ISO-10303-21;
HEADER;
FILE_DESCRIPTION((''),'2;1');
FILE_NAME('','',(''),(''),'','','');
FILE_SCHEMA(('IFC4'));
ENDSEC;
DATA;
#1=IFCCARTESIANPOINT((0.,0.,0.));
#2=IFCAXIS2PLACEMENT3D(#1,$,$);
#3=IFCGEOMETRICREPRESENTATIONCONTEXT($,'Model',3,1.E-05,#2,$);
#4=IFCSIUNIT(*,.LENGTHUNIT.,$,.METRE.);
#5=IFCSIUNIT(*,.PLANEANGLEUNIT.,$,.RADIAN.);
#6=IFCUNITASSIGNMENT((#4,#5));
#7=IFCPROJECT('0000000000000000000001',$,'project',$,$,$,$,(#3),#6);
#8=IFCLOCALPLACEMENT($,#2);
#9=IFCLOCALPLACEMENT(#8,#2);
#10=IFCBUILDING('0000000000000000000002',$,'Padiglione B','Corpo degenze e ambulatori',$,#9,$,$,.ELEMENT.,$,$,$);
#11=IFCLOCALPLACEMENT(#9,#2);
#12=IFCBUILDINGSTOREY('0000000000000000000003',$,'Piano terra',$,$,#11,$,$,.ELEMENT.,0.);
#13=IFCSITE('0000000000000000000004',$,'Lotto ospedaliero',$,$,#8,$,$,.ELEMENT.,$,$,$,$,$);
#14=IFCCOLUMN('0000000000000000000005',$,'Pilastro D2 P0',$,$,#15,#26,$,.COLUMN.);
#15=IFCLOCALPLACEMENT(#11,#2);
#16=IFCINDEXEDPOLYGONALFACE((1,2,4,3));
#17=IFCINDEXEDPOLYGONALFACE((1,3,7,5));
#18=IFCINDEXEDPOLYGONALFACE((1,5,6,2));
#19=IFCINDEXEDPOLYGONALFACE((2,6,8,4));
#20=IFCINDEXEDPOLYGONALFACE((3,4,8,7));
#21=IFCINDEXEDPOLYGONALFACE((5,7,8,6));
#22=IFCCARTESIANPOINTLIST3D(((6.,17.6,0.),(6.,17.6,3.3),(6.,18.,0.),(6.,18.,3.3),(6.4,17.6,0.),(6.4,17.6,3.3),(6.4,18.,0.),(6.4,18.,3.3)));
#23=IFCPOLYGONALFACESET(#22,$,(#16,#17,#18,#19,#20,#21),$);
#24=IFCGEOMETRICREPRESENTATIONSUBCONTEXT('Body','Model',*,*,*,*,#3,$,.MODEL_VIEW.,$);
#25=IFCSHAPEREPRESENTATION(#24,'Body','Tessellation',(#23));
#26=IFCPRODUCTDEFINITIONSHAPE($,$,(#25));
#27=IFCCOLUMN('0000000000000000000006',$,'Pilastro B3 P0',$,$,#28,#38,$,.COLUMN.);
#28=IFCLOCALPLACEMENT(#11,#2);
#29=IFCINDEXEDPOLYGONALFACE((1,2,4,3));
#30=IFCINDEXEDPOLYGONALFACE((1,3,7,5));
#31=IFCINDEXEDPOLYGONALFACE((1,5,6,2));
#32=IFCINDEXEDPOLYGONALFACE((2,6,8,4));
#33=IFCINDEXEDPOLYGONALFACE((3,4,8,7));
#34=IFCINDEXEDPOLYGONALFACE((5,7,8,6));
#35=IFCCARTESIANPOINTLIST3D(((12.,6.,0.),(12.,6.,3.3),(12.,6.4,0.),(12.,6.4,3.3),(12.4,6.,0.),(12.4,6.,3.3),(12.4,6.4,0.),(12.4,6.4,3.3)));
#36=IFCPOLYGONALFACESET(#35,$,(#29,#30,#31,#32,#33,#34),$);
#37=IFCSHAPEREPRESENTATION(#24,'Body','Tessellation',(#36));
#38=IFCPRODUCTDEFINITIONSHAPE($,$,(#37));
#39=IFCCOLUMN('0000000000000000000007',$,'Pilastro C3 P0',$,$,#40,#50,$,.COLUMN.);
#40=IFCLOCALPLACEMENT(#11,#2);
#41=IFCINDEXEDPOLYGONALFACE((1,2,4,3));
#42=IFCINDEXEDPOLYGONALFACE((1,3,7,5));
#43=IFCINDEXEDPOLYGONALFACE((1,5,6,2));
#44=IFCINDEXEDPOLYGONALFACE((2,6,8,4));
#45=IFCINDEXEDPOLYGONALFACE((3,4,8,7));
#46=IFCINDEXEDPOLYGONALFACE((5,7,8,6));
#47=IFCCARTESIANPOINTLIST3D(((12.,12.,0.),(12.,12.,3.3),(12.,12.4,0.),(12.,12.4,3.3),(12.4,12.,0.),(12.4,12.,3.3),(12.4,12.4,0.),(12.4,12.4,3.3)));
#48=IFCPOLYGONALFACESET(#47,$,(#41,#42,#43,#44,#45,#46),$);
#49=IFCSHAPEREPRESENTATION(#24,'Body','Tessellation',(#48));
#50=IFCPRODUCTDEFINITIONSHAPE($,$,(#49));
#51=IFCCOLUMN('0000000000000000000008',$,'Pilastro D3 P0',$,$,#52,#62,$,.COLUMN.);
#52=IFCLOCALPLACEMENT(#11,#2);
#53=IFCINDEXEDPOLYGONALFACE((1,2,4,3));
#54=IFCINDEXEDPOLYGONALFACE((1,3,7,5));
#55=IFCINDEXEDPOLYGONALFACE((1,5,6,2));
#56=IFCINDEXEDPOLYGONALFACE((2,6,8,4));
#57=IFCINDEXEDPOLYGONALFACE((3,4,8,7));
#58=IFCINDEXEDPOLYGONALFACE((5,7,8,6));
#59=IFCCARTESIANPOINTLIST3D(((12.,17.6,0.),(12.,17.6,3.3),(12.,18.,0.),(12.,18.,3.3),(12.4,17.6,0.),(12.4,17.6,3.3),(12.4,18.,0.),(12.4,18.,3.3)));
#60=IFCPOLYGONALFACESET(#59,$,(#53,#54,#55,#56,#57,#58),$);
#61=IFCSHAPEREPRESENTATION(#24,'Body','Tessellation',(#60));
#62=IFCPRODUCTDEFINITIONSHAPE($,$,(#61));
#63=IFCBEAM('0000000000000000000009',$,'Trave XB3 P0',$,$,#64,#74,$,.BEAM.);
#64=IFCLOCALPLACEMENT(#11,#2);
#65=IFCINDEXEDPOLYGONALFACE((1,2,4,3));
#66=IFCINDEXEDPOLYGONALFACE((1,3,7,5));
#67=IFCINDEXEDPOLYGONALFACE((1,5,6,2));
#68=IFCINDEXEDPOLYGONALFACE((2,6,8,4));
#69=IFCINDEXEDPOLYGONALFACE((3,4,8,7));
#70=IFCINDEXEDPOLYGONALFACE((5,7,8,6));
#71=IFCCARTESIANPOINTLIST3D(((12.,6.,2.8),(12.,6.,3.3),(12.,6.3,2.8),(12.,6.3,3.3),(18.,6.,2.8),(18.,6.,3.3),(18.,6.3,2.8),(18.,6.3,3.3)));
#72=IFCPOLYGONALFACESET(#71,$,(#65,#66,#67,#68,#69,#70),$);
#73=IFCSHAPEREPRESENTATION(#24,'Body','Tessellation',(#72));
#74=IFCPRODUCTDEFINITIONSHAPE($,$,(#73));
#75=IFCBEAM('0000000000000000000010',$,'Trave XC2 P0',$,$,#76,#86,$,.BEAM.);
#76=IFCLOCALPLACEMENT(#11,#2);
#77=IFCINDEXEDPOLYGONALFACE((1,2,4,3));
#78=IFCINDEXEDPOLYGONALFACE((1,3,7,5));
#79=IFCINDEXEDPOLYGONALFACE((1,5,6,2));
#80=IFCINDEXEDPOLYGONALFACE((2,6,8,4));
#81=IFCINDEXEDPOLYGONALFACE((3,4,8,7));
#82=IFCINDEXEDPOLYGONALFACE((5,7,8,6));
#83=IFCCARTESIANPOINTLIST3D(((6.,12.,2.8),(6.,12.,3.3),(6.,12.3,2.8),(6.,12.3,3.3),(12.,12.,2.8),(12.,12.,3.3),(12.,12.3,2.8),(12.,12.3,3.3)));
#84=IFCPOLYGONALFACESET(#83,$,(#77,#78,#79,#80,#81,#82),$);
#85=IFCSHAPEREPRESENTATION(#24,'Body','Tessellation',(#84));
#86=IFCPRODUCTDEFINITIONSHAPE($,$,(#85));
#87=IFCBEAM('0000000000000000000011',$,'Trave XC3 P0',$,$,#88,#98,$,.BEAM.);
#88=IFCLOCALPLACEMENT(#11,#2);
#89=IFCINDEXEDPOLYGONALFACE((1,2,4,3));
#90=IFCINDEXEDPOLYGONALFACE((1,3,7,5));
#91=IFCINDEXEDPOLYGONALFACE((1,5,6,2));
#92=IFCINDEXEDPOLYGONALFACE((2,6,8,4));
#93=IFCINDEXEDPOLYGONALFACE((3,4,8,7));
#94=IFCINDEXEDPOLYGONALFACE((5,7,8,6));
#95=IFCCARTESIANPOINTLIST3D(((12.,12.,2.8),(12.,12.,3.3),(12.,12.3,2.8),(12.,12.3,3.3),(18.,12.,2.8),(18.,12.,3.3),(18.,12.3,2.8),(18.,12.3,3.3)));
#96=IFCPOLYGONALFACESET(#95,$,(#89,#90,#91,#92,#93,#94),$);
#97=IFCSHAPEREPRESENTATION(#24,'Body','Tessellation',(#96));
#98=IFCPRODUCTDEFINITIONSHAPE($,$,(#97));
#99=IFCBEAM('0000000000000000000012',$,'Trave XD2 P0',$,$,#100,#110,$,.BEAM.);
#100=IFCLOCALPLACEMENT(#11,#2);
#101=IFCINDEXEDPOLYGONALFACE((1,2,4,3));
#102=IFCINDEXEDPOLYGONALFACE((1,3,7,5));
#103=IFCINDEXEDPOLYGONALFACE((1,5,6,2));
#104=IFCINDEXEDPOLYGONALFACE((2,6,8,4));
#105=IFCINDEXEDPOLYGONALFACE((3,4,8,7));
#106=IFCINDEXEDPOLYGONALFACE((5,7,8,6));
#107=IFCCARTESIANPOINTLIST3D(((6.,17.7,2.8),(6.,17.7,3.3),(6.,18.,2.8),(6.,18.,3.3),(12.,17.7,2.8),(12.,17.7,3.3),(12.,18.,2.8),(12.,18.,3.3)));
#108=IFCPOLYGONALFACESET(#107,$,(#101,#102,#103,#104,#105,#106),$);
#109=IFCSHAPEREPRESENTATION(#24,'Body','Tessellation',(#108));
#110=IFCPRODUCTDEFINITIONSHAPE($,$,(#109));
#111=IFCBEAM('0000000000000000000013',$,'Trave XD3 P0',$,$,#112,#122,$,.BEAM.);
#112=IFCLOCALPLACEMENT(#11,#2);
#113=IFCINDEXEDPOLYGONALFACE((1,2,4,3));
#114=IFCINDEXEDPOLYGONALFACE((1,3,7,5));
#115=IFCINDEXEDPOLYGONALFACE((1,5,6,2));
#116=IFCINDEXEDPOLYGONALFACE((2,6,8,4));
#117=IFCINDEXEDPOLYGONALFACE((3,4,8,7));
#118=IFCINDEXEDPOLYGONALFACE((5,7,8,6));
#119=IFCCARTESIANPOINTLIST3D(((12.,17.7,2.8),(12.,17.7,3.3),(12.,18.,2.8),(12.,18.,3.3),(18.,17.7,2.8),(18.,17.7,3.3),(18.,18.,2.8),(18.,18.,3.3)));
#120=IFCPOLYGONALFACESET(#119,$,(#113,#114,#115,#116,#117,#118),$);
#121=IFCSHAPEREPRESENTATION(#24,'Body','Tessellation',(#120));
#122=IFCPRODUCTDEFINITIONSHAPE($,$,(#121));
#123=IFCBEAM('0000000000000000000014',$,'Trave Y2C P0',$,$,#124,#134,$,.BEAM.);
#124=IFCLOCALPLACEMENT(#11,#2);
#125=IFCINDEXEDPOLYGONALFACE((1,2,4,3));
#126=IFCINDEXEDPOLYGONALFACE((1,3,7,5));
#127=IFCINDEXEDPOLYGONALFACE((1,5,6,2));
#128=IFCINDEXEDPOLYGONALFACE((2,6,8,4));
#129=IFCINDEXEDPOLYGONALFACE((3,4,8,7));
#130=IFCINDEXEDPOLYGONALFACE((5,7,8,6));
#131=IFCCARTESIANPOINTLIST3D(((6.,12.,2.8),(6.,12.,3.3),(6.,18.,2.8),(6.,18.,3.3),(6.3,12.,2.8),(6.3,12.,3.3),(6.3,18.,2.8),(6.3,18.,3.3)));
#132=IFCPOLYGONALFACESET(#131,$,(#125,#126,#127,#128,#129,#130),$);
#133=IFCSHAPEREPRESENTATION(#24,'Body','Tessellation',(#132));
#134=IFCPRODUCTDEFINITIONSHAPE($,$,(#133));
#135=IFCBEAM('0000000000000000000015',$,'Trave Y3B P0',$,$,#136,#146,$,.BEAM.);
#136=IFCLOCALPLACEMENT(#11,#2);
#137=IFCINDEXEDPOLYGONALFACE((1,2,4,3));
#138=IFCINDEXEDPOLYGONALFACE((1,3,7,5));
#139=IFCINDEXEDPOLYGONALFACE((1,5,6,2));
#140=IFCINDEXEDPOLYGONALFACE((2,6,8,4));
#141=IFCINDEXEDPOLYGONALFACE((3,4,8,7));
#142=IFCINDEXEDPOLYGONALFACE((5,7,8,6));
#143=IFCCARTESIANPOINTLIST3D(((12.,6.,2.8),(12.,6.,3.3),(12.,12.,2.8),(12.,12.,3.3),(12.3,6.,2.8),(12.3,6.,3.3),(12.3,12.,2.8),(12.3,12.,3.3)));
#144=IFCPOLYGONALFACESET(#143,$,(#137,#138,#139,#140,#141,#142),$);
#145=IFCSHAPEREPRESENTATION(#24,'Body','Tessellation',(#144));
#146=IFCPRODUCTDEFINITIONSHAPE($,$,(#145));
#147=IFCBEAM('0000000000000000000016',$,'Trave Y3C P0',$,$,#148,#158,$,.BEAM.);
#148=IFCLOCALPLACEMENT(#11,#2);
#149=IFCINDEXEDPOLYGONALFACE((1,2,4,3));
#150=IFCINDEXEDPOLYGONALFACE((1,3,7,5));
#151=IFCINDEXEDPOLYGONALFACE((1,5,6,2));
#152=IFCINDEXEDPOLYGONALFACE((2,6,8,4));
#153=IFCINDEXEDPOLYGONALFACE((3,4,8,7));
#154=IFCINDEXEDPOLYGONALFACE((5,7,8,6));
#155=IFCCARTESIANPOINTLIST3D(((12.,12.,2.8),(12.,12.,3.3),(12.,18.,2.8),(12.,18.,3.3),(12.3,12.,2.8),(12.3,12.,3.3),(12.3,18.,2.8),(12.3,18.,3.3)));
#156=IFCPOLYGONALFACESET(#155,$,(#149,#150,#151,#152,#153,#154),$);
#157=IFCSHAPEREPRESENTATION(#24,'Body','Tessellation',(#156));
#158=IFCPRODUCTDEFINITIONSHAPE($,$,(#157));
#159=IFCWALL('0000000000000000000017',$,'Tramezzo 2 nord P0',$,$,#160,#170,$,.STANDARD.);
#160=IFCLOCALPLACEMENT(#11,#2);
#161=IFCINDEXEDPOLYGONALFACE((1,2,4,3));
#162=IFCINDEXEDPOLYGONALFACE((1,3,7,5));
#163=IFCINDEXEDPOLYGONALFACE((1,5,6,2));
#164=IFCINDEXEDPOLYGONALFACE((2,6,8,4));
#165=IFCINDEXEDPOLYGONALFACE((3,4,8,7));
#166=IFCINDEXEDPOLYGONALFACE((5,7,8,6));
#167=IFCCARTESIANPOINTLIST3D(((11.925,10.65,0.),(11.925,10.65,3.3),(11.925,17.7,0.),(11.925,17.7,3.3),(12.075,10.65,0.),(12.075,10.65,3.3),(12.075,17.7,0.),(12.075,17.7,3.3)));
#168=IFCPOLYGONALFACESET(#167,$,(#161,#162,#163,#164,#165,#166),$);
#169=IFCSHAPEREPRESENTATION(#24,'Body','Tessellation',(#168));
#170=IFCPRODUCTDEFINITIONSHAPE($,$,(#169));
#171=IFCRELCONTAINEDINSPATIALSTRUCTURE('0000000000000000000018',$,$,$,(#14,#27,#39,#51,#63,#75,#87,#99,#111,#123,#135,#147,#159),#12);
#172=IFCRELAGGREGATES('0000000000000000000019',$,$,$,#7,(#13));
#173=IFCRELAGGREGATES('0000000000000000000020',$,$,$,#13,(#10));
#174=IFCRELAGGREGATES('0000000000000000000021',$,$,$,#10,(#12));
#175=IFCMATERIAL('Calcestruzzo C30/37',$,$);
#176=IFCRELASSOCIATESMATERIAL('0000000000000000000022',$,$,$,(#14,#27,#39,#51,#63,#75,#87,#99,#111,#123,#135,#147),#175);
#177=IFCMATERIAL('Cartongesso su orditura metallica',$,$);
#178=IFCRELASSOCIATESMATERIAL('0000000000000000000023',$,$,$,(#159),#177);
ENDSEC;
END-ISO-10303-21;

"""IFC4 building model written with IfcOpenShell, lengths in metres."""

from ifc_helpers import new_model, si_unit, frame, frame_2d, origin, place, context, subcontext, project, spatial, rectangle, extrude, material, element, save


model = new_model("IFC4")

# Units and contexts
model_context = context("Model", 3, precision=1e-05, world=origin())
body_context = subcontext(model_context, "Body", "Model", "MODEL_VIEW")
ifc_project = project(units=[si_unit("LENGTHUNIT", "METRE"), si_unit("PLANEANGLEUNIT", "RADIAN")], contexts=[model_context])

# Site, building, storey
site_placement = place(None, origin())
site = spatial("IfcSite", under=ifc_project, at=site_placement, Name="Lotto ospedaliero", CompositionType="ELEMENT")
building_placement = place(site_placement, origin())
building = spatial("IfcBuilding", under=site, at=building_placement, Name="Padiglione B", Description="Corpo degenze e ambulatori", CompositionType="ELEMENT")
storey_placement = place(building_placement, origin())
storey = spatial("IfcBuildingStorey", under=building, at=storey_placement, Name="Piano terra", CompositionType="ELEMENT", Elevation=0.0)

# Columns
ifc_material_1 = material(Name="Calcestruzzo C30/37")
for number, where, name in (
    (1, (6.0, 17.6, 0.0), "Pilastro D2 P0"),
    (2, (12.0, 6.0, 0.0), "Pilastro B3 P0"),
    (3, (12.0, 12.0, 0.0), "Pilastro C3 P0"),
    (4, (12.0, 17.6, 0.0), "Pilastro D3 P0"),
):
    element("IfcColumn", number, at=place(storey_placement, frame(where)), inside=storey, material=ifc_material_1, Name=name, PredefinedType="COLUMN", context=body_context, shape_type="SweptSolid", body=[
        extrude(rectangle(XDim=0.4, YDim=0.4, at=frame_2d((0.2, 0.2))), origin(), (0.0, 0.0, 1.0), 3.3),
    ])

# Beams
for number, where, name in (
    (5, (12.0, 6.0, 2.8), "Trave XB3 P0"),
    (6, (6.0, 12.0, 2.8), "Trave XC2 P0"),
    (7, (12.0, 12.0, 2.8), "Trave XC3 P0"),
    (8, (6.0, 17.7, 2.8), "Trave XD2 P0"),
    (9, (12.0, 17.7, 2.8), "Trave XD3 P0"),
):
    element("IfcBeam", number, at=place(storey_placement, frame(where)), inside=storey, material=ifc_material_1, Name=name, PredefinedType="BEAM", context=body_context, shape_type="SweptSolid", body=[
        extrude(rectangle(XDim=6.0, YDim=0.3, at=frame_2d((3.0, 0.15))), origin(), (0.0, 0.0, 1.0), 0.5),
    ])
for number, where, name in (
    (10, (6.0, 12.0, 2.8), "Trave Y2C P0"),
    (11, (12.0, 6.0, 2.8), "Trave Y3B P0"),
    (12, (12.0, 12.0, 2.8), "Trave Y3C P0"),
):
    element("IfcBeam", number, at=place(storey_placement, frame(where)), inside=storey, material=ifc_material_1, Name=name, PredefinedType="BEAM", context=body_context, shape_type="SweptSolid", body=[
        extrude(rectangle(XDim=0.3, YDim=6.0, at=frame_2d((0.15, 3.0))), origin(), (0.0, 0.0, 1.0), 0.5),
    ])

# Wall
ifc_material_2 = material(Name="Cartongesso su orditura metallica")
wall_placement = place(storey_placement, frame((11.925, 10.65, 0.0)))
element("IfcWall", 13, at=wall_placement, inside=storey, material=ifc_material_2, Name="Tramezzo 2 nord P0", PredefinedType="STANDARD", context=body_context, shape_type="SweptSolid", body=[
    extrude(rectangle(XDim=0.15, YDim=7.05, at=frame_2d((0.075, 3.525))), origin(), (0.0, 0.0, 1.0), 3.3),
])

save(model, "model.ifc")
